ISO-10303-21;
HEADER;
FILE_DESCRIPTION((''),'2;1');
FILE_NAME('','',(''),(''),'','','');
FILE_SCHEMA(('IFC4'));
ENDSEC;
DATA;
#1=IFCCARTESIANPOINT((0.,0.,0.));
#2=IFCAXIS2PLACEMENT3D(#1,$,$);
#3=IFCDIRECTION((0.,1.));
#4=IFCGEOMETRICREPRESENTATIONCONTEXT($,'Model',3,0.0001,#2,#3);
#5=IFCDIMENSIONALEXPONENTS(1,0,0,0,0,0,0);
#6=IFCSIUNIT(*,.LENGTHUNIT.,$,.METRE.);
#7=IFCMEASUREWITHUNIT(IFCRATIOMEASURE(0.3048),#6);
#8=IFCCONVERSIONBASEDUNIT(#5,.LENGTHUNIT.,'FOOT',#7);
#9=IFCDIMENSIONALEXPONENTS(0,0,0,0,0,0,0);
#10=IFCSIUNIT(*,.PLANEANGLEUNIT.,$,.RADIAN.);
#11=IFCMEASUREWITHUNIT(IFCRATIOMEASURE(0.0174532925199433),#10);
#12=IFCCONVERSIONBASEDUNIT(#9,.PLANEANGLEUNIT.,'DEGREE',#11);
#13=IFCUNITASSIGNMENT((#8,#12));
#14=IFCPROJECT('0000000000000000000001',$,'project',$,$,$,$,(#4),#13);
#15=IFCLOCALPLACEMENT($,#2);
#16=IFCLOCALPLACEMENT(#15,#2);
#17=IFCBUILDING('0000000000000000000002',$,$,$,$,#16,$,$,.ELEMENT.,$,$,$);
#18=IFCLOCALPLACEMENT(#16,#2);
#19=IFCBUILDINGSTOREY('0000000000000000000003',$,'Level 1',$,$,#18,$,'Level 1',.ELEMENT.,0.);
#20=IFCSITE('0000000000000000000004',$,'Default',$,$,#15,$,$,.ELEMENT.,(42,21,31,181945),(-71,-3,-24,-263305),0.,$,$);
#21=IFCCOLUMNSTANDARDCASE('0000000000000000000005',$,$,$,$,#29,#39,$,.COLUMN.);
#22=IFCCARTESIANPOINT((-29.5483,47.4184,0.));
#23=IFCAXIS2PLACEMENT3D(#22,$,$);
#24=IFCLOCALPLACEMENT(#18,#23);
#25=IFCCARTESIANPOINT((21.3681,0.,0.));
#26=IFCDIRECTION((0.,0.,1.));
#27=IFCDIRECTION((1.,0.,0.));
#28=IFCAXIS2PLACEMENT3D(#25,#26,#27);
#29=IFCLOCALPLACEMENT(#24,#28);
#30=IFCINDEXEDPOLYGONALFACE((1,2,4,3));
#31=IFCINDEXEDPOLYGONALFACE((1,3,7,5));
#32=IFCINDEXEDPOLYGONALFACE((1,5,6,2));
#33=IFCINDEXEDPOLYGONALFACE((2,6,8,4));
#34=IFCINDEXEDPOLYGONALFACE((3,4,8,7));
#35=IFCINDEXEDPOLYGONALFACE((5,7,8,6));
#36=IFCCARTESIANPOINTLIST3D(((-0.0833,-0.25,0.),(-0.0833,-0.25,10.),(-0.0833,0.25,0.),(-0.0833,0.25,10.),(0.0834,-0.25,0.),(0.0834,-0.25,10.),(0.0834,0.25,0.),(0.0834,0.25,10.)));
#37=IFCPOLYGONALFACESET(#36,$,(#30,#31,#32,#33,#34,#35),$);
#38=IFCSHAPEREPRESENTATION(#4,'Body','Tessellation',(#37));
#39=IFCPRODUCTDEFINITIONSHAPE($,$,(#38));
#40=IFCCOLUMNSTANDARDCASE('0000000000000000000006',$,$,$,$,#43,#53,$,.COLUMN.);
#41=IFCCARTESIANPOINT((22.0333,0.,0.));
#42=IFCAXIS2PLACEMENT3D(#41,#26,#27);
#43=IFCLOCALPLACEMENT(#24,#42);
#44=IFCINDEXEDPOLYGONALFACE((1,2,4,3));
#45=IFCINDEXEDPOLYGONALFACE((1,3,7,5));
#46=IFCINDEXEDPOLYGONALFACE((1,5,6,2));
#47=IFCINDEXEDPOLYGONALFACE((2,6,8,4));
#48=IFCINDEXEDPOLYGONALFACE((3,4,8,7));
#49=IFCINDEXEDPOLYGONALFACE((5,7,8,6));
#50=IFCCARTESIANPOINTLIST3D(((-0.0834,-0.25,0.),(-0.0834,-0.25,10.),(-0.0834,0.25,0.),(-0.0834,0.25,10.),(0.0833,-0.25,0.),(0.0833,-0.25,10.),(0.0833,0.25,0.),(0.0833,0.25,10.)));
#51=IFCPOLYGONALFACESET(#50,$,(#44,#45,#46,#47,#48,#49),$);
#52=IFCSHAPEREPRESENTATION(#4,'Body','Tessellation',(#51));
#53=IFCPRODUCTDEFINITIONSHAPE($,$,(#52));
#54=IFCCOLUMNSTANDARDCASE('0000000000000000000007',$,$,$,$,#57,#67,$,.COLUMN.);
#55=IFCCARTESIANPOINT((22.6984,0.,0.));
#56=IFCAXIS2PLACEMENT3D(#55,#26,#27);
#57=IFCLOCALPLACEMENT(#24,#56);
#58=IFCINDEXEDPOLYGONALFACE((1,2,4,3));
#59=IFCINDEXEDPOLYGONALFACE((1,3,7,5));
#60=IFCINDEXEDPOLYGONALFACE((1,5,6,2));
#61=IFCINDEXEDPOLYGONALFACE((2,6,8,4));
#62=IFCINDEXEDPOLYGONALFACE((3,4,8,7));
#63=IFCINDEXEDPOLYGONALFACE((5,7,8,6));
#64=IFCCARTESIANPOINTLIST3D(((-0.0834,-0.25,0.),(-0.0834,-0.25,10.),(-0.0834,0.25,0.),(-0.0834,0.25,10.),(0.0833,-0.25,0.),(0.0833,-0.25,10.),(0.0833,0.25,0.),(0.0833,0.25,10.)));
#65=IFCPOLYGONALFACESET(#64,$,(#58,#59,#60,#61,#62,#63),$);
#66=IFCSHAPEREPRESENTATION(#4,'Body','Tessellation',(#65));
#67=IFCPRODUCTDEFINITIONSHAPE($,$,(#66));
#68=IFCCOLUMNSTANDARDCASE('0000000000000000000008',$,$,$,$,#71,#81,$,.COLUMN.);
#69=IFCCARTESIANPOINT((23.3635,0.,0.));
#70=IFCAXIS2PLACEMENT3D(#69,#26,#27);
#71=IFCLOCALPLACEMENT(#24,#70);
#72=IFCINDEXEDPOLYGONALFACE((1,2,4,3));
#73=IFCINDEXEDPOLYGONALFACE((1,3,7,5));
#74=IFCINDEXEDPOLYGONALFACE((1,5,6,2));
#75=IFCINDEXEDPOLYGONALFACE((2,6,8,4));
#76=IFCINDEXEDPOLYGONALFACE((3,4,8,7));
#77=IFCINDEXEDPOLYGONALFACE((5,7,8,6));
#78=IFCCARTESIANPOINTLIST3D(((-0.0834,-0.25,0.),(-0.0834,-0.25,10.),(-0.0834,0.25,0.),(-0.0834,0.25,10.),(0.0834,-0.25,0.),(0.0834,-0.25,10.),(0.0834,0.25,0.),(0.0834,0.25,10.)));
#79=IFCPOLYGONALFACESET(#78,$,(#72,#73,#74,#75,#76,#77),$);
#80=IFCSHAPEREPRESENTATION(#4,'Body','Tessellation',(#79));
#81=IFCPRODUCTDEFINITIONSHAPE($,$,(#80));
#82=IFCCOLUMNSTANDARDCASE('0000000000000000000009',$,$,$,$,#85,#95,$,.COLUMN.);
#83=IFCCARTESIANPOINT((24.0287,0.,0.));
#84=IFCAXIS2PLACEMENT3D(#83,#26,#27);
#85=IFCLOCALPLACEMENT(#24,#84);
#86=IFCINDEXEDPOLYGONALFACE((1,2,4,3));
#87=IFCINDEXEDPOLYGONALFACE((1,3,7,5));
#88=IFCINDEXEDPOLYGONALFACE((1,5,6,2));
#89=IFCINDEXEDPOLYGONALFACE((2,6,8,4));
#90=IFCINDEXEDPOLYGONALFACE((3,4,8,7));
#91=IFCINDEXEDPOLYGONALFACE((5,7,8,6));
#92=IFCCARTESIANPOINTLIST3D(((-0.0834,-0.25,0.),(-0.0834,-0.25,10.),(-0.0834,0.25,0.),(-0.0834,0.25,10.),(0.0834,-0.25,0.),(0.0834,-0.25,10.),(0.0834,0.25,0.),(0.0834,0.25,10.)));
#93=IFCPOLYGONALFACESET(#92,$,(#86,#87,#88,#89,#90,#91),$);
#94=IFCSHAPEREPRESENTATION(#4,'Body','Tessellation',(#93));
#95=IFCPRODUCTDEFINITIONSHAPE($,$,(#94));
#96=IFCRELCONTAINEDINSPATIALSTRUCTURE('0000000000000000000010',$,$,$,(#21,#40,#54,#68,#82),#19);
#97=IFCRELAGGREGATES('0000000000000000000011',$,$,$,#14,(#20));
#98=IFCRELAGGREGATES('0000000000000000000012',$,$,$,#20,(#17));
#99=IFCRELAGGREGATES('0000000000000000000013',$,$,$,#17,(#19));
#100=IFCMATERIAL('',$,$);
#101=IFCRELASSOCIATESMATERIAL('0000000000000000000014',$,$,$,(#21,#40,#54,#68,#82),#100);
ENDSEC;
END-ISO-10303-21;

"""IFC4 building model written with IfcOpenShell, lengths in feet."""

from ifc_helpers import new_model, entity, si_unit, converted_unit, direction, frame, origin, place, context, project, spatial, rectangle, extrude, material, element, save


model = new_model("IFC4")

# Units and contexts
model_context = context("Model", 3, precision=0.0001, world=origin(), true_north=direction((0.0, 1.0)))
ifc_project = project(units=[converted_unit("LENGTHUNIT", "FOOT", entity("IfcRatioMeasure", 0.3048), si_unit("LENGTHUNIT", "METRE"), dimensions=[1, 0, 0, 0, 0, 0, 0]), converted_unit("PLANEANGLEUNIT", "DEGREE", entity("IfcRatioMeasure", 0.0174532925199433), si_unit("PLANEANGLEUNIT", "RADIAN"), dimensions=[0, 0, 0, 0, 0, 0, 0])], contexts=[model_context])

# Site, building, storey
site_placement = place(None, origin())
site = spatial("IfcSite", under=ifc_project, at=site_placement, Name="Default", CompositionType="ELEMENT", RefLatitude=(42, 21, 31, 181945), RefLongitude=(-71, -3, -24, -263305), RefElevation=0.0)
building_placement = place(site_placement, origin())
building = spatial("IfcBuilding", under=site, at=building_placement, CompositionType="ELEMENT")
storey_placement = place(building_placement, origin())
storey = spatial("IfcBuildingStorey", under=building, at=storey_placement, Name="Level 1", LongName="Level 1", CompositionType="ELEMENT", Elevation=0.0)

# Columns
ifc_material_1 = material(Name="")
placement = place(storey_placement, frame((-29.5483, 47.4184, 0.0)))
for number, where, z_axis, x_axis in (
    (1, (21.3681, 0.0, 0.0), (0.0, 0.0, 1.0), (1.0, 0.0, 0.0)),
    (2, (22.0333, 0.0, 0.0), (0.0, 0.0, 1.0), (1.0, 0.0, 0.0)),
    (3, (22.6984, 0.0, 0.0), (0.0, 0.0, 1.0), (1.0, 0.0, 0.0)),
    (4, (23.3635, 0.0, 0.0), (0.0, 0.0, 1.0), (1.0, 0.0, 0.0)),
    (5, (24.0287, 0.0, 0.0), (0.0, 0.0, 1.0), (1.0, 0.0, 0.0)),
):
    element("IfcColumnStandardCase", number, at=place(placement, frame(where, z_axis=z_axis, x_axis=x_axis)), inside=storey, material=ifc_material_1, PredefinedType="COLUMN", context=model_context, shape_type="SweptSolid", body=[
        extrude(rectangle(XDim=0.1667, YDim=0.5), origin(), (0.0, 0.0, 1.0), 10.0),
    ])

save(model, "model.ifc")
